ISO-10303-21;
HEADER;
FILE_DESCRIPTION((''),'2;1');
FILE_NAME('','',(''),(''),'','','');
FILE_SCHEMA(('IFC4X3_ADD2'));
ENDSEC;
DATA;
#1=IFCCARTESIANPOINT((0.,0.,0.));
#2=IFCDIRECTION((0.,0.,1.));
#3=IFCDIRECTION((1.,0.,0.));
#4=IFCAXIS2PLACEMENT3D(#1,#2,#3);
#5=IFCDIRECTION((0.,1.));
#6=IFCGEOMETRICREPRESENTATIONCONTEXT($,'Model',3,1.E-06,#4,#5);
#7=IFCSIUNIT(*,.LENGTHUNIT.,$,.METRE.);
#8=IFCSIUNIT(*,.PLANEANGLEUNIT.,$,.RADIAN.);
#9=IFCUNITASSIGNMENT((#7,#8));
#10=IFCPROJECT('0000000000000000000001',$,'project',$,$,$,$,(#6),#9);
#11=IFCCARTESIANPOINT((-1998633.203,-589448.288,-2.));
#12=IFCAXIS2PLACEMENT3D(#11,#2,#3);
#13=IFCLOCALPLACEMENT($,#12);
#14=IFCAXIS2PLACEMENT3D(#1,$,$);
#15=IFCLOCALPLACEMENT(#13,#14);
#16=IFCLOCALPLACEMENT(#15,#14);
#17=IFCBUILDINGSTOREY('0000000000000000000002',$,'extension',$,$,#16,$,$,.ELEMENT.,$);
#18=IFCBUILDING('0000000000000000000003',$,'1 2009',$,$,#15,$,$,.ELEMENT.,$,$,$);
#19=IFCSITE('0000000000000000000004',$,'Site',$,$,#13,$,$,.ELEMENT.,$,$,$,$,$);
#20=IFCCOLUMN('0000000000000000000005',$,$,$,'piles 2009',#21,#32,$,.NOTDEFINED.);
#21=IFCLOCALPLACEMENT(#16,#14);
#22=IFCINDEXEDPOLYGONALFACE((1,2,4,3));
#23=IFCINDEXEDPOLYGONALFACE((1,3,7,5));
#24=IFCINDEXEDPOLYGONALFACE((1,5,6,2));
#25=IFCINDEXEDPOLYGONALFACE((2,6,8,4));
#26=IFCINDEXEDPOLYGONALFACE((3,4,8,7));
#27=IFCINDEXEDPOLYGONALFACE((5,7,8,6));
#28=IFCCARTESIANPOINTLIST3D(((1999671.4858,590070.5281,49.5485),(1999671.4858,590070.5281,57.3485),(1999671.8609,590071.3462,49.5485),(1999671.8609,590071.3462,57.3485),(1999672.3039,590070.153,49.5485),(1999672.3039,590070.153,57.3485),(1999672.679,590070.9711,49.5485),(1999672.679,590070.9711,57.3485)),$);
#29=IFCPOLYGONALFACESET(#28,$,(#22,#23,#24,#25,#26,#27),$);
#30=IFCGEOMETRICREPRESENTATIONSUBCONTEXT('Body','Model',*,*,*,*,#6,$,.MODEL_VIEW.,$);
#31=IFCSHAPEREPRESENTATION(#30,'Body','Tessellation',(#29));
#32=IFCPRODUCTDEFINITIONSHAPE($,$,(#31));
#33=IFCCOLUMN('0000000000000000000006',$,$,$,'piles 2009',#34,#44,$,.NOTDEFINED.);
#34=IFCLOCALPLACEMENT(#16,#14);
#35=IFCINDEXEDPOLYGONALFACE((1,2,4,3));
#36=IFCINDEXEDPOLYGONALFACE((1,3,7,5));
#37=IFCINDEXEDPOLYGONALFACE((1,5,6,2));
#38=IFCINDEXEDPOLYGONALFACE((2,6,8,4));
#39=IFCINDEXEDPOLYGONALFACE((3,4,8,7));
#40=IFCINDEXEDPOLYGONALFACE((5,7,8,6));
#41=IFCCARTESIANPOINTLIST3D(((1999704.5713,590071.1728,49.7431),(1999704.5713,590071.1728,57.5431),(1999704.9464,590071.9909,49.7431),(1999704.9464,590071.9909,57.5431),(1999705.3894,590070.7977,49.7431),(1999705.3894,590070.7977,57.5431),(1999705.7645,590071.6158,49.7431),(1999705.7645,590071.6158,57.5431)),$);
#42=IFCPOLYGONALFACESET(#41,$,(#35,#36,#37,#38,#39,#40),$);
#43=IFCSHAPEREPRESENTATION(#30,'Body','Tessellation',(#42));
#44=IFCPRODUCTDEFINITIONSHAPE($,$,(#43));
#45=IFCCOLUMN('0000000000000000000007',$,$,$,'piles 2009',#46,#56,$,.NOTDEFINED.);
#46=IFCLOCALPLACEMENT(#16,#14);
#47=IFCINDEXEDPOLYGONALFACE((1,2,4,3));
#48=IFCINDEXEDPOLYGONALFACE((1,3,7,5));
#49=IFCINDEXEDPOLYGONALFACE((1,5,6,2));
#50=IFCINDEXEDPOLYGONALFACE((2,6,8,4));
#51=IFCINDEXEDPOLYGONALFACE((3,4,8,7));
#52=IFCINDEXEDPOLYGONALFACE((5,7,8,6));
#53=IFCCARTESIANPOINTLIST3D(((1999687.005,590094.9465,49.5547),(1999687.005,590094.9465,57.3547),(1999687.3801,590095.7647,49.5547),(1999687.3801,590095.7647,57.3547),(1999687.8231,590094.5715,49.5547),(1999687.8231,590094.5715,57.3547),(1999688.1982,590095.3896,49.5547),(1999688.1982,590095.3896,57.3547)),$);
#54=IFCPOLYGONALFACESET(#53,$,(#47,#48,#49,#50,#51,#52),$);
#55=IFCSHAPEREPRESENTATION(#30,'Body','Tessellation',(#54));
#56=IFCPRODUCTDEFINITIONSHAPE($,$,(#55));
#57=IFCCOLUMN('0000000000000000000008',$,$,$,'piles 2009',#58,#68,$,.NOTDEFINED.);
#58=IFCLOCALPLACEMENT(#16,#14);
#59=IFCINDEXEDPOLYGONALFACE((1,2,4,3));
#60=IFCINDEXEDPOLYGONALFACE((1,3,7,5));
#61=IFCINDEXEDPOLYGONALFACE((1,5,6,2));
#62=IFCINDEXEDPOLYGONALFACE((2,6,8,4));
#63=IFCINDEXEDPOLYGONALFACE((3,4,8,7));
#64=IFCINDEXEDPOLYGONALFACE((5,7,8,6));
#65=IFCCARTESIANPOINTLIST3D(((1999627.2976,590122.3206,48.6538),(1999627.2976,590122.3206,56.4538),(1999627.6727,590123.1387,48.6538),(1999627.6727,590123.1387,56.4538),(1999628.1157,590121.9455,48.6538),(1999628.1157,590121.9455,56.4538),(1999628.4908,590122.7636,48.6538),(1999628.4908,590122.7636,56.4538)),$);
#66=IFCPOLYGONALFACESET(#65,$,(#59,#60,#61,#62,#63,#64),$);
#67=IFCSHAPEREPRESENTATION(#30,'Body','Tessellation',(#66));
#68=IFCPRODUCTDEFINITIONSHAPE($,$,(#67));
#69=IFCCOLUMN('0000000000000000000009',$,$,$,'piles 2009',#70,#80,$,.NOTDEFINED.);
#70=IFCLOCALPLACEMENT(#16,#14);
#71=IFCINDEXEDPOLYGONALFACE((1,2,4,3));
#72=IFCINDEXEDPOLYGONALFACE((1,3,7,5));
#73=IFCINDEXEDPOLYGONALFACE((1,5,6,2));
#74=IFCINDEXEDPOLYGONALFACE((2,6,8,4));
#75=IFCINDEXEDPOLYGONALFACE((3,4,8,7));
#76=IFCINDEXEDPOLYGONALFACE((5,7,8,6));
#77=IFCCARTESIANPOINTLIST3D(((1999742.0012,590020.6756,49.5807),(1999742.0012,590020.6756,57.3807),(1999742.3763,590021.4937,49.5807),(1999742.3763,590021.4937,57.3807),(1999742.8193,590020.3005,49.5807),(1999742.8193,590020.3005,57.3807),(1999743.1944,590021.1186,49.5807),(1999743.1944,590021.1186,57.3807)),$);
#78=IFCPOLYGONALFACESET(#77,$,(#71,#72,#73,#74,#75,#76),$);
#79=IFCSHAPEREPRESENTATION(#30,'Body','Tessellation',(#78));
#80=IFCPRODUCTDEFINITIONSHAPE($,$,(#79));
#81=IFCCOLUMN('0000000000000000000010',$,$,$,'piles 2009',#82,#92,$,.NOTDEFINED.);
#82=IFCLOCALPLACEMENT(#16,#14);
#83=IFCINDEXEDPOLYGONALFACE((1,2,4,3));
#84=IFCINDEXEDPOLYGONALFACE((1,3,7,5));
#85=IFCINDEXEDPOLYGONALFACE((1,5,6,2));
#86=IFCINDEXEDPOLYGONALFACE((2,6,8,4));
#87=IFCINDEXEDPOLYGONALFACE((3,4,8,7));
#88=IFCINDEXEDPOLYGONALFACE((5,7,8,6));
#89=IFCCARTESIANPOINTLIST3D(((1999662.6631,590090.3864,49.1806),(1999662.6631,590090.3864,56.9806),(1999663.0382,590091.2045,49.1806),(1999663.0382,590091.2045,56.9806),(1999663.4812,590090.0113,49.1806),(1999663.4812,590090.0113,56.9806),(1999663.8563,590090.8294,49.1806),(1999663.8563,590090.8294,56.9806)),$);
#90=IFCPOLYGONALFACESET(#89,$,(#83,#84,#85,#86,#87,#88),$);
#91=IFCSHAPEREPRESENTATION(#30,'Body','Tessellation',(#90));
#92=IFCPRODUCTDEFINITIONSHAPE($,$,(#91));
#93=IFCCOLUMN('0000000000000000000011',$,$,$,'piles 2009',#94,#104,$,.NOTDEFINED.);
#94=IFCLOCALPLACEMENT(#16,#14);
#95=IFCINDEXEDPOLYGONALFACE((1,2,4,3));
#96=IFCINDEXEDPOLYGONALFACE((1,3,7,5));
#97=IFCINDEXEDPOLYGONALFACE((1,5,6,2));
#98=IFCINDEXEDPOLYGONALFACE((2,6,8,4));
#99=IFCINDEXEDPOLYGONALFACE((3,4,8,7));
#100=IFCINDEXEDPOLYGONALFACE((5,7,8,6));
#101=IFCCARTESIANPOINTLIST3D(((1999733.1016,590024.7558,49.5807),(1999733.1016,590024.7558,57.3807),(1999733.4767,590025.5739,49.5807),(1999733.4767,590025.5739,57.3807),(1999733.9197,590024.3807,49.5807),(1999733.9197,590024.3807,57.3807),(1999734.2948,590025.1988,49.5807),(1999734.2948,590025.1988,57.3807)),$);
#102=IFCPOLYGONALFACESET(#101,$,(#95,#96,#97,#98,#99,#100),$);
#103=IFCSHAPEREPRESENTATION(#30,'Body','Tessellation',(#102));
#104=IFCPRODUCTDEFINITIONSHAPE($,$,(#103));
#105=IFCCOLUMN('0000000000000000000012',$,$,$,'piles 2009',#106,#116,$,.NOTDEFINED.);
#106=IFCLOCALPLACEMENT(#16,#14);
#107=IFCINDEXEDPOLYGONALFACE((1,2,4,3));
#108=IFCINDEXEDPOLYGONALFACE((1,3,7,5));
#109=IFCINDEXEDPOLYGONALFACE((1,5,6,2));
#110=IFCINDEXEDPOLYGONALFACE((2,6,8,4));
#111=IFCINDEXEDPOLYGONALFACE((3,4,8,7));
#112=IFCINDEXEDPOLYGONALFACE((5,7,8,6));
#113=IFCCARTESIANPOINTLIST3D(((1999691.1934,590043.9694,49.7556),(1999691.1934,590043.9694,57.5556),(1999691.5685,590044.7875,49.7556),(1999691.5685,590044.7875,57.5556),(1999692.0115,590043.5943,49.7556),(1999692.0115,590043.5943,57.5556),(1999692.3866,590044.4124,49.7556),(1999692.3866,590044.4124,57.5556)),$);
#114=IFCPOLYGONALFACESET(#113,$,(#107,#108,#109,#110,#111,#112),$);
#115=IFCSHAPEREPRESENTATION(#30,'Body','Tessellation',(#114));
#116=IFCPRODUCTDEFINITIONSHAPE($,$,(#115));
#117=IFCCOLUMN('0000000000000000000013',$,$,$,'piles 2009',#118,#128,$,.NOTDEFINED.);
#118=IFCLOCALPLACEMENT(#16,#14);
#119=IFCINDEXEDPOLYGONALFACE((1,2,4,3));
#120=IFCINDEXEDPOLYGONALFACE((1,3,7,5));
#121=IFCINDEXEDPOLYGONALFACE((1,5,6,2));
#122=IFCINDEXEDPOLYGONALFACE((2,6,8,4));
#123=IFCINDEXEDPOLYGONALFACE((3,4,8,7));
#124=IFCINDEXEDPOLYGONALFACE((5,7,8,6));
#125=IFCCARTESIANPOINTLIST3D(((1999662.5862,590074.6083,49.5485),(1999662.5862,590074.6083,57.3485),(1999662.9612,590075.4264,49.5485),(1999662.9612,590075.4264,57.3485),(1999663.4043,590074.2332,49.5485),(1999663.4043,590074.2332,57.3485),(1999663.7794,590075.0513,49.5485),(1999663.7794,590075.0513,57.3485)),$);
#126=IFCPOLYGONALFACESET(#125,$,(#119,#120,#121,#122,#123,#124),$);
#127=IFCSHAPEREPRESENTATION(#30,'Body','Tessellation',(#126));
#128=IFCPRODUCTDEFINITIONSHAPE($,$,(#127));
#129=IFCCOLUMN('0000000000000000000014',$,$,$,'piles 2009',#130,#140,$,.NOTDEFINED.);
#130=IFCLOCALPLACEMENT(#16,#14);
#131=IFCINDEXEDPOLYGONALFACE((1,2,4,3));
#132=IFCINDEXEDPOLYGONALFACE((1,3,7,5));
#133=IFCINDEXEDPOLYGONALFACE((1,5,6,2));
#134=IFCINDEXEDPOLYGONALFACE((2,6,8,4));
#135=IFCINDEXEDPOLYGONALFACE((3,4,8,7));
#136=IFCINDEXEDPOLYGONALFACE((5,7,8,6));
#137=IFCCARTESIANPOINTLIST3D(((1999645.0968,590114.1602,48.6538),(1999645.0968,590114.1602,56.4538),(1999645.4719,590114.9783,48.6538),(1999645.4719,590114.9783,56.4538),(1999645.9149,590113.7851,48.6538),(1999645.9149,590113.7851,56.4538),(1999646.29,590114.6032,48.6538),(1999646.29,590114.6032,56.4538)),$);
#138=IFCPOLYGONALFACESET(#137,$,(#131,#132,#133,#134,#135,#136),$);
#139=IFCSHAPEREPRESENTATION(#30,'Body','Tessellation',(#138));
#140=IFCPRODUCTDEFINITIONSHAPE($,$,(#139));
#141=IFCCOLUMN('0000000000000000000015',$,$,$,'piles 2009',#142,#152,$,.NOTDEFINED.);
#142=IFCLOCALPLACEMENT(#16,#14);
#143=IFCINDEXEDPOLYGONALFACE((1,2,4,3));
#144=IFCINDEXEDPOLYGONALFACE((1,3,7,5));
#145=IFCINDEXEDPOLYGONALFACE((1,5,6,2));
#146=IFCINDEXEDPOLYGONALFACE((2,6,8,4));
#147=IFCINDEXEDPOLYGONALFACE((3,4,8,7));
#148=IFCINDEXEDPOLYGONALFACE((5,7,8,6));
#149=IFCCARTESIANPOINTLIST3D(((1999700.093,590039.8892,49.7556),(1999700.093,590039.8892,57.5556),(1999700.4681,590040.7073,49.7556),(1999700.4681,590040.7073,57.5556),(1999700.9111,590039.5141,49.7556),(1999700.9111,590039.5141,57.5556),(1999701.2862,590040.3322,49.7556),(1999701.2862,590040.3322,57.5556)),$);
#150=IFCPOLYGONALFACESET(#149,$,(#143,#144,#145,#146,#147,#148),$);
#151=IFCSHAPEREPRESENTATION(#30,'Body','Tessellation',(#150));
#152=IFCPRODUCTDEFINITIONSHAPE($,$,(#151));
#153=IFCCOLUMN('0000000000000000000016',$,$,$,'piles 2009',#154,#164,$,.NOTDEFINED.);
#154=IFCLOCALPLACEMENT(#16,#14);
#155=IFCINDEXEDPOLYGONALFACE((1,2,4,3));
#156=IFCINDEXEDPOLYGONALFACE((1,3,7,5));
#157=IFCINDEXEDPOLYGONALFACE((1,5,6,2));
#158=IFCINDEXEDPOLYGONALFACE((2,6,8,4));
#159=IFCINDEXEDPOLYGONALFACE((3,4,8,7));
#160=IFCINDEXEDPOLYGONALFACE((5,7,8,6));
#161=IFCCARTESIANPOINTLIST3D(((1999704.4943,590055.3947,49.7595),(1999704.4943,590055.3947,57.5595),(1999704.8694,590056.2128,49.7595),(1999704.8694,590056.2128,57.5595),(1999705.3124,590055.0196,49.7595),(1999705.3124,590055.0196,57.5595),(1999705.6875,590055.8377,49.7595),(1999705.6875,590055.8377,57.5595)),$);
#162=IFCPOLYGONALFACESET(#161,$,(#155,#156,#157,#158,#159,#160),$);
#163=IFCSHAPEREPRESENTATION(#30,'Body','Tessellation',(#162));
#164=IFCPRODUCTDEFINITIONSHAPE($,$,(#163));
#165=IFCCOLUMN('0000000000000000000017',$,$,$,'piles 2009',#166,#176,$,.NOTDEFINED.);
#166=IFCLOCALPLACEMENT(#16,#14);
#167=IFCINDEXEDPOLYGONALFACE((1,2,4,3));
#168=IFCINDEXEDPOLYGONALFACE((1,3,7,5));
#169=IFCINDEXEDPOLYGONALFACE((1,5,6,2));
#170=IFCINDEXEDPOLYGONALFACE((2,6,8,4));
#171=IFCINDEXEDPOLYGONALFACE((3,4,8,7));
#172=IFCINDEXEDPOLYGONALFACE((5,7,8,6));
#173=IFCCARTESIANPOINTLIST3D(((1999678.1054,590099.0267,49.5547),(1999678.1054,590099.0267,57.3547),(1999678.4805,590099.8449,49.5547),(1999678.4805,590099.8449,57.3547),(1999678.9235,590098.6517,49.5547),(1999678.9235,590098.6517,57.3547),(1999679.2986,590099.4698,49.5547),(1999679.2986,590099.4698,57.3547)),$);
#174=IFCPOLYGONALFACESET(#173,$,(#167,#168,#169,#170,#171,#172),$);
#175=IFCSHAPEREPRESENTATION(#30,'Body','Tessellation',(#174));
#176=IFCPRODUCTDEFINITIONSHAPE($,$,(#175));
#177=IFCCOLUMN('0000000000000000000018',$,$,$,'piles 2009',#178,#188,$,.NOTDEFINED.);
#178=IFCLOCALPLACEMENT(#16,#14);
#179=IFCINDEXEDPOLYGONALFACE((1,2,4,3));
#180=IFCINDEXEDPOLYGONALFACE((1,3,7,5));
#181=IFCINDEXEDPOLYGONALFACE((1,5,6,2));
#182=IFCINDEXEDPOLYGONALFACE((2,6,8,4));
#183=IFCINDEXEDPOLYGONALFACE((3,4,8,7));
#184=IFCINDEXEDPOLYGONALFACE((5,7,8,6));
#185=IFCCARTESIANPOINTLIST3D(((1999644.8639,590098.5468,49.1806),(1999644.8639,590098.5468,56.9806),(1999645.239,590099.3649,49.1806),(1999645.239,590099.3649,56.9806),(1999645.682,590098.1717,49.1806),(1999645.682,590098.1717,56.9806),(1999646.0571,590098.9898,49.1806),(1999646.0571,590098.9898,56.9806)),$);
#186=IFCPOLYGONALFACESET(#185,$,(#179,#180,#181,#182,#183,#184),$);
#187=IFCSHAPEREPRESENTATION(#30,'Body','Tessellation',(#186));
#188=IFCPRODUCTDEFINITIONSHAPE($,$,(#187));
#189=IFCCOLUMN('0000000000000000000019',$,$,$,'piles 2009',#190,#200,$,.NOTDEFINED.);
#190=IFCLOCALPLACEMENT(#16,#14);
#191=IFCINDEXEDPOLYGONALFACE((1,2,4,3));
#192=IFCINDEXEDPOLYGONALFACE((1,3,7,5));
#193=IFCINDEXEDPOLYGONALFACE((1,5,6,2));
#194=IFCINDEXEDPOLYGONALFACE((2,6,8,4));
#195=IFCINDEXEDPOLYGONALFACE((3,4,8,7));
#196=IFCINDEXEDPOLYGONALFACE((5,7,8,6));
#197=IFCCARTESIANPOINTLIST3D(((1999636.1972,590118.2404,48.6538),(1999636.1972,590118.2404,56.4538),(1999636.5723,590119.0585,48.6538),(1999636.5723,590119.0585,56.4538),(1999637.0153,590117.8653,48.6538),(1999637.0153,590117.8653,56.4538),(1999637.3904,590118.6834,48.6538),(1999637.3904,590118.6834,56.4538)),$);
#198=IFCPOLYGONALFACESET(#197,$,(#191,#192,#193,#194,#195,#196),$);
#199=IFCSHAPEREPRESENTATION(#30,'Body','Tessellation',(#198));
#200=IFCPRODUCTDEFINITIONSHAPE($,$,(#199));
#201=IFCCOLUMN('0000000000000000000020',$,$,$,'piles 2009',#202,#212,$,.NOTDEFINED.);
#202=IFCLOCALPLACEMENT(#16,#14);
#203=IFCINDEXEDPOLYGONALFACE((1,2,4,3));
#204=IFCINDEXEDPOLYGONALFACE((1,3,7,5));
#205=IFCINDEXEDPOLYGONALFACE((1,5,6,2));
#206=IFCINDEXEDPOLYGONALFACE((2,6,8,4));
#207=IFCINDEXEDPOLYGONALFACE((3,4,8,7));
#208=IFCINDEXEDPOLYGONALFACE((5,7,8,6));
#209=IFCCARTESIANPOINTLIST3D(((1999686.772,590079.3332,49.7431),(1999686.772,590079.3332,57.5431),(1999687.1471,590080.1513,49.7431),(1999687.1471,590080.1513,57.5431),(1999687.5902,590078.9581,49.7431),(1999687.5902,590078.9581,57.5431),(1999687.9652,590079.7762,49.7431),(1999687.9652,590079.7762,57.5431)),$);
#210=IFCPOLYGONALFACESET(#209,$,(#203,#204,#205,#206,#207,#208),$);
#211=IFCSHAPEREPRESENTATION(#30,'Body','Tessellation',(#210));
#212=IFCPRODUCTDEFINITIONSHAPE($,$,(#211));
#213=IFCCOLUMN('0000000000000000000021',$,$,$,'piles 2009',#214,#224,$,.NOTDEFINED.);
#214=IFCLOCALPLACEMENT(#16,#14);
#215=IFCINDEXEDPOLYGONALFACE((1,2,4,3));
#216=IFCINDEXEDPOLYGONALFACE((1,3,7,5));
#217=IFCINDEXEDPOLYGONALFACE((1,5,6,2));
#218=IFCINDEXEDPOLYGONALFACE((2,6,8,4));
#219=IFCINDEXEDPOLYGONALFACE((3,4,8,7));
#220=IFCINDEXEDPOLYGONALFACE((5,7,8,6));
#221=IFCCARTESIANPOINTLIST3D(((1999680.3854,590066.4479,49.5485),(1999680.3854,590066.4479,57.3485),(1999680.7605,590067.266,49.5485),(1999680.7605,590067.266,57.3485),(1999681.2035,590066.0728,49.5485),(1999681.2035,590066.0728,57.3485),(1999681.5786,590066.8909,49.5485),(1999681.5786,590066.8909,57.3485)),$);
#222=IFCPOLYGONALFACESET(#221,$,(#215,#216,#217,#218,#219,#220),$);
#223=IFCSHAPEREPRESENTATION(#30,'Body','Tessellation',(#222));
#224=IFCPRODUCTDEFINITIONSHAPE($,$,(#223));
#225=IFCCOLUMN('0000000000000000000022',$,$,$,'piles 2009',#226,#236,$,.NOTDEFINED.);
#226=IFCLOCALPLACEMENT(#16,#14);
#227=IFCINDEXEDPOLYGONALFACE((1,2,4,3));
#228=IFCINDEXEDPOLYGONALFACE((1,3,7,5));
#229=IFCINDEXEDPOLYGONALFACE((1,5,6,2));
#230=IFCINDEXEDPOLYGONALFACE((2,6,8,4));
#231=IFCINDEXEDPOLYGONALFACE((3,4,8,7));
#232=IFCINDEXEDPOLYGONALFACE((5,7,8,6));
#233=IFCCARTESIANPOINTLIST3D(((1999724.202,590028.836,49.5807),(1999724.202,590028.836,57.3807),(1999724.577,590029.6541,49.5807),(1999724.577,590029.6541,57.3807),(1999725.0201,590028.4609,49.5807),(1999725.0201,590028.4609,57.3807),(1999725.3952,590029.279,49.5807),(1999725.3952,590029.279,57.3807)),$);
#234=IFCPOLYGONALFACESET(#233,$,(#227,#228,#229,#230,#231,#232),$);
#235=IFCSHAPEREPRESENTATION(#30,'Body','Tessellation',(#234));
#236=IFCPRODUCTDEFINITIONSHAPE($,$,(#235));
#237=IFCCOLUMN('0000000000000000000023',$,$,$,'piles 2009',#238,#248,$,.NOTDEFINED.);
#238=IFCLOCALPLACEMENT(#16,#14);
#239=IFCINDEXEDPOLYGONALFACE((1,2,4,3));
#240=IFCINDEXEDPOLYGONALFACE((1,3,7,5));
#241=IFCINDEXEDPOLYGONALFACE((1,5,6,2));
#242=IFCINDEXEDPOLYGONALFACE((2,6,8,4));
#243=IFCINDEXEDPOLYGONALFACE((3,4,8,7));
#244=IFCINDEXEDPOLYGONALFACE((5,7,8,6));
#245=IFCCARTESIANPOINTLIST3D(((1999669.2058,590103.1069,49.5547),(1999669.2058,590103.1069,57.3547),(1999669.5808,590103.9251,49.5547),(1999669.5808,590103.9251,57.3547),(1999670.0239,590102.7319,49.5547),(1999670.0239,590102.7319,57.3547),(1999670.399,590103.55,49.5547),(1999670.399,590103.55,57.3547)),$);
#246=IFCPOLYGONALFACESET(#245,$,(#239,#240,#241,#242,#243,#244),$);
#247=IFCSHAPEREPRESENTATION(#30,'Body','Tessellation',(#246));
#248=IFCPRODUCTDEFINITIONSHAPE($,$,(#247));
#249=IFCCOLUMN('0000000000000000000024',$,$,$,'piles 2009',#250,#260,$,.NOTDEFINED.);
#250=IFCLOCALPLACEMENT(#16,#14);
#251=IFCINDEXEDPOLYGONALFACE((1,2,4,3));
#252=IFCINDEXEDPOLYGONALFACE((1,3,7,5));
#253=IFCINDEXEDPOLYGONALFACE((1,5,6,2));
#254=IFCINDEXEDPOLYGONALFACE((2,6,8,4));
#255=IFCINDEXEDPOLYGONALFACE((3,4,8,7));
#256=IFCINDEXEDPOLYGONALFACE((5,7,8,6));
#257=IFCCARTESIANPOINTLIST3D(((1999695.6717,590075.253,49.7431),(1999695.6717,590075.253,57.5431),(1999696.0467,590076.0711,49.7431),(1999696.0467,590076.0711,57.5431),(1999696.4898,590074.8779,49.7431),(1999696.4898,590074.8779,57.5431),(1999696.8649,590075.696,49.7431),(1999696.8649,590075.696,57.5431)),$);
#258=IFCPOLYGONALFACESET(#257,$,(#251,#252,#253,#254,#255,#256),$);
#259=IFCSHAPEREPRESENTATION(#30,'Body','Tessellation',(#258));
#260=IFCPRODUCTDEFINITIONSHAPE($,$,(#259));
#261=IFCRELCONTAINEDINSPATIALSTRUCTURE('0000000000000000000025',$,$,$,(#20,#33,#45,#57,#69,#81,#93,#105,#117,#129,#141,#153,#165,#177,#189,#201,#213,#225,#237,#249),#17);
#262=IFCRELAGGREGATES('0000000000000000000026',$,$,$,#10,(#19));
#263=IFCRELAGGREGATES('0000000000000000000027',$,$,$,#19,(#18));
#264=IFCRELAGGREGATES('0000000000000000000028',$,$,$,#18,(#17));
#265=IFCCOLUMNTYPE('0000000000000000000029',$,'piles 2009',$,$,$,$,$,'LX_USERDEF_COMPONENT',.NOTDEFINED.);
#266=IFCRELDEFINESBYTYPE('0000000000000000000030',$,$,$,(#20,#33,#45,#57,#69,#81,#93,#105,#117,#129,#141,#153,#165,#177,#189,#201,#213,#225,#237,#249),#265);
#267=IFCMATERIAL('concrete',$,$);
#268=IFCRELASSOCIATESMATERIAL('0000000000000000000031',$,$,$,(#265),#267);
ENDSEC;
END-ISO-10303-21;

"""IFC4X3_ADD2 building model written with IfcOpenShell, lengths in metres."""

from ifc_helpers import new_model, si_unit, direction, frame, frame_2d, origin, origin_with_axes, place, context, subcontext, project, spatial, rectangle, extrude, material, type_object, element, save


model = new_model("IFC4X3_ADD2")

# Units and contexts
model_context = context("Model", 3, precision=1e-06, world=origin_with_axes(), true_north=direction((0.0, 1.0)))
body_context = subcontext(model_context, "Body", "Model", "MODEL_VIEW")
ifc_project = project(units=[si_unit("LENGTHUNIT", "METRE"), si_unit("PLANEANGLEUNIT", "RADIAN")], contexts=[model_context])

# Site, building, storey
site_placement = place(None, frame((-1998633.203, -589448.288, -2.0), z_axis=(0.0, 0.0, 1.0), x_axis=(1.0, 0.0, 0.0)))
site = spatial("IfcSite", under=ifc_project, at=site_placement, Name="Site", CompositionType="ELEMENT")
building_placement = place(site_placement, origin())
building = spatial("IfcBuilding", under=site, at=building_placement, Name="1 2009", CompositionType="ELEMENT")
storey_placement = place(building_placement, origin())
storey = spatial("IfcBuildingStorey", under=building, at=storey_placement, Name="extension", CompositionType="ELEMENT")

# Columns
ifc_material = material(Name="concrete")
column_type = type_object("IfcColumnType", Name="piles 2009", ElementType="LX_USERDEF_COMPONENT", PredefinedType="NOTDEFINED", material=ifc_material)
for number, where, z_axis, x_axis in (
    (1, (1999672.3039, 590070.153, 49.5485), (0.0, 0.0, 1.0), (0.416757, 0.909018, 0.0)),
    (2, (1999705.3894, 590070.7977, 49.7431), (0.0, 0.0, 1.0), (0.416757, 0.909018, 0.0)),
    (3, (1999687.8231, 590094.5715, 49.5547), (0.0, 0.0, 1.0), (0.416757, 0.909018, 0.0)),
    (4, (1999628.1157, 590121.9455, 48.6538), (0.0, 0.0, 1.0), (0.416757, 0.909018, 0.0)),
    (5, (1999742.8193, 590020.3005, 49.5807), (0.0, 0.0, 1.0), (0.416757, 0.909018, 0.0)),
    (6, (1999663.4812, 590090.0113, 49.1806), (0.0, 0.0, 1.0), (0.416757, 0.909018, 0.0)),
    (7, (1999733.9197, 590024.3807, 49.5807), (0.0, 0.0, 1.0), (0.416757, 0.909018, 0.0)),
    (8, (1999692.0115, 590043.5943, 49.7556), (0.0, 0.0, 1.0), (0.416757, 0.909018, 0.0)),
    (9, (1999663.4043, 590074.2332, 49.5485), (0.0, 0.0, 1.0), (0.416757, 0.909018, 0.0)),
    (10, (1999645.9149, 590113.7851, 48.6538), (0.0, 0.0, 1.0), (0.416757, 0.909018, 0.0)),
    (11, (1999700.9111, 590039.5141, 49.7556), (0.0, 0.0, 1.0), (0.416757, 0.909018, 0.0)),
    (12, (1999705.3124, 590055.0196, 49.7595), (0.0, 0.0, 1.0), (0.416757, 0.909018, 0.0)),
    (13, (1999678.9235, 590098.6517, 49.5547), (0.0, 0.0, 1.0), (0.416757, 0.909018, 0.0)),
    (14, (1999645.682, 590098.1717, 49.1806), (0.0, 0.0, 1.0), (0.416757, 0.909018, 0.0)),
    (15, (1999637.0153, 590117.8653, 48.6538), (0.0, 0.0, 1.0), (0.416757, 0.909018, 0.0)),
    (16, (1999687.5902, 590078.9581, 49.7431), (0.0, 0.0, 1.0), (0.416757, 0.909018, 0.0)),
    (17, (1999681.2035, 590066.0728, 49.5485), (0.0, 0.0, 1.0), (0.416757, 0.909018, 0.0)),
    (18, (1999725.0201, 590028.4609, 49.5807), (0.0, 0.0, 1.0), (0.416757, 0.909018, 0.0)),
    (19, (1999670.0239, 590102.7319, 49.5547), (0.0, 0.0, 1.0), (0.416757, 0.909018, 0.0)),
    (20, (1999696.4898, 590074.8779, 49.7431), (0.0, 0.0, 1.0), (0.416757, 0.909018, 0.0)),
):
    element("IfcColumn", number, at=place(storey_placement, frame(where, z_axis=z_axis, x_axis=x_axis)), inside=storey, type_object=column_type, ObjectType="piles 2009", PredefinedType="NOTDEFINED", context=body_context, shape_type="SweptSolid", body=[
        extrude(rectangle(XDim=0.9, YDim=0.9, at=frame_2d((0.45, 0.45), x_axis=(1.0, 0.0))), origin_with_axes(), (0.0, 0.0, 1.0), 7.8),
    ])

save(model, "model.ifc")
